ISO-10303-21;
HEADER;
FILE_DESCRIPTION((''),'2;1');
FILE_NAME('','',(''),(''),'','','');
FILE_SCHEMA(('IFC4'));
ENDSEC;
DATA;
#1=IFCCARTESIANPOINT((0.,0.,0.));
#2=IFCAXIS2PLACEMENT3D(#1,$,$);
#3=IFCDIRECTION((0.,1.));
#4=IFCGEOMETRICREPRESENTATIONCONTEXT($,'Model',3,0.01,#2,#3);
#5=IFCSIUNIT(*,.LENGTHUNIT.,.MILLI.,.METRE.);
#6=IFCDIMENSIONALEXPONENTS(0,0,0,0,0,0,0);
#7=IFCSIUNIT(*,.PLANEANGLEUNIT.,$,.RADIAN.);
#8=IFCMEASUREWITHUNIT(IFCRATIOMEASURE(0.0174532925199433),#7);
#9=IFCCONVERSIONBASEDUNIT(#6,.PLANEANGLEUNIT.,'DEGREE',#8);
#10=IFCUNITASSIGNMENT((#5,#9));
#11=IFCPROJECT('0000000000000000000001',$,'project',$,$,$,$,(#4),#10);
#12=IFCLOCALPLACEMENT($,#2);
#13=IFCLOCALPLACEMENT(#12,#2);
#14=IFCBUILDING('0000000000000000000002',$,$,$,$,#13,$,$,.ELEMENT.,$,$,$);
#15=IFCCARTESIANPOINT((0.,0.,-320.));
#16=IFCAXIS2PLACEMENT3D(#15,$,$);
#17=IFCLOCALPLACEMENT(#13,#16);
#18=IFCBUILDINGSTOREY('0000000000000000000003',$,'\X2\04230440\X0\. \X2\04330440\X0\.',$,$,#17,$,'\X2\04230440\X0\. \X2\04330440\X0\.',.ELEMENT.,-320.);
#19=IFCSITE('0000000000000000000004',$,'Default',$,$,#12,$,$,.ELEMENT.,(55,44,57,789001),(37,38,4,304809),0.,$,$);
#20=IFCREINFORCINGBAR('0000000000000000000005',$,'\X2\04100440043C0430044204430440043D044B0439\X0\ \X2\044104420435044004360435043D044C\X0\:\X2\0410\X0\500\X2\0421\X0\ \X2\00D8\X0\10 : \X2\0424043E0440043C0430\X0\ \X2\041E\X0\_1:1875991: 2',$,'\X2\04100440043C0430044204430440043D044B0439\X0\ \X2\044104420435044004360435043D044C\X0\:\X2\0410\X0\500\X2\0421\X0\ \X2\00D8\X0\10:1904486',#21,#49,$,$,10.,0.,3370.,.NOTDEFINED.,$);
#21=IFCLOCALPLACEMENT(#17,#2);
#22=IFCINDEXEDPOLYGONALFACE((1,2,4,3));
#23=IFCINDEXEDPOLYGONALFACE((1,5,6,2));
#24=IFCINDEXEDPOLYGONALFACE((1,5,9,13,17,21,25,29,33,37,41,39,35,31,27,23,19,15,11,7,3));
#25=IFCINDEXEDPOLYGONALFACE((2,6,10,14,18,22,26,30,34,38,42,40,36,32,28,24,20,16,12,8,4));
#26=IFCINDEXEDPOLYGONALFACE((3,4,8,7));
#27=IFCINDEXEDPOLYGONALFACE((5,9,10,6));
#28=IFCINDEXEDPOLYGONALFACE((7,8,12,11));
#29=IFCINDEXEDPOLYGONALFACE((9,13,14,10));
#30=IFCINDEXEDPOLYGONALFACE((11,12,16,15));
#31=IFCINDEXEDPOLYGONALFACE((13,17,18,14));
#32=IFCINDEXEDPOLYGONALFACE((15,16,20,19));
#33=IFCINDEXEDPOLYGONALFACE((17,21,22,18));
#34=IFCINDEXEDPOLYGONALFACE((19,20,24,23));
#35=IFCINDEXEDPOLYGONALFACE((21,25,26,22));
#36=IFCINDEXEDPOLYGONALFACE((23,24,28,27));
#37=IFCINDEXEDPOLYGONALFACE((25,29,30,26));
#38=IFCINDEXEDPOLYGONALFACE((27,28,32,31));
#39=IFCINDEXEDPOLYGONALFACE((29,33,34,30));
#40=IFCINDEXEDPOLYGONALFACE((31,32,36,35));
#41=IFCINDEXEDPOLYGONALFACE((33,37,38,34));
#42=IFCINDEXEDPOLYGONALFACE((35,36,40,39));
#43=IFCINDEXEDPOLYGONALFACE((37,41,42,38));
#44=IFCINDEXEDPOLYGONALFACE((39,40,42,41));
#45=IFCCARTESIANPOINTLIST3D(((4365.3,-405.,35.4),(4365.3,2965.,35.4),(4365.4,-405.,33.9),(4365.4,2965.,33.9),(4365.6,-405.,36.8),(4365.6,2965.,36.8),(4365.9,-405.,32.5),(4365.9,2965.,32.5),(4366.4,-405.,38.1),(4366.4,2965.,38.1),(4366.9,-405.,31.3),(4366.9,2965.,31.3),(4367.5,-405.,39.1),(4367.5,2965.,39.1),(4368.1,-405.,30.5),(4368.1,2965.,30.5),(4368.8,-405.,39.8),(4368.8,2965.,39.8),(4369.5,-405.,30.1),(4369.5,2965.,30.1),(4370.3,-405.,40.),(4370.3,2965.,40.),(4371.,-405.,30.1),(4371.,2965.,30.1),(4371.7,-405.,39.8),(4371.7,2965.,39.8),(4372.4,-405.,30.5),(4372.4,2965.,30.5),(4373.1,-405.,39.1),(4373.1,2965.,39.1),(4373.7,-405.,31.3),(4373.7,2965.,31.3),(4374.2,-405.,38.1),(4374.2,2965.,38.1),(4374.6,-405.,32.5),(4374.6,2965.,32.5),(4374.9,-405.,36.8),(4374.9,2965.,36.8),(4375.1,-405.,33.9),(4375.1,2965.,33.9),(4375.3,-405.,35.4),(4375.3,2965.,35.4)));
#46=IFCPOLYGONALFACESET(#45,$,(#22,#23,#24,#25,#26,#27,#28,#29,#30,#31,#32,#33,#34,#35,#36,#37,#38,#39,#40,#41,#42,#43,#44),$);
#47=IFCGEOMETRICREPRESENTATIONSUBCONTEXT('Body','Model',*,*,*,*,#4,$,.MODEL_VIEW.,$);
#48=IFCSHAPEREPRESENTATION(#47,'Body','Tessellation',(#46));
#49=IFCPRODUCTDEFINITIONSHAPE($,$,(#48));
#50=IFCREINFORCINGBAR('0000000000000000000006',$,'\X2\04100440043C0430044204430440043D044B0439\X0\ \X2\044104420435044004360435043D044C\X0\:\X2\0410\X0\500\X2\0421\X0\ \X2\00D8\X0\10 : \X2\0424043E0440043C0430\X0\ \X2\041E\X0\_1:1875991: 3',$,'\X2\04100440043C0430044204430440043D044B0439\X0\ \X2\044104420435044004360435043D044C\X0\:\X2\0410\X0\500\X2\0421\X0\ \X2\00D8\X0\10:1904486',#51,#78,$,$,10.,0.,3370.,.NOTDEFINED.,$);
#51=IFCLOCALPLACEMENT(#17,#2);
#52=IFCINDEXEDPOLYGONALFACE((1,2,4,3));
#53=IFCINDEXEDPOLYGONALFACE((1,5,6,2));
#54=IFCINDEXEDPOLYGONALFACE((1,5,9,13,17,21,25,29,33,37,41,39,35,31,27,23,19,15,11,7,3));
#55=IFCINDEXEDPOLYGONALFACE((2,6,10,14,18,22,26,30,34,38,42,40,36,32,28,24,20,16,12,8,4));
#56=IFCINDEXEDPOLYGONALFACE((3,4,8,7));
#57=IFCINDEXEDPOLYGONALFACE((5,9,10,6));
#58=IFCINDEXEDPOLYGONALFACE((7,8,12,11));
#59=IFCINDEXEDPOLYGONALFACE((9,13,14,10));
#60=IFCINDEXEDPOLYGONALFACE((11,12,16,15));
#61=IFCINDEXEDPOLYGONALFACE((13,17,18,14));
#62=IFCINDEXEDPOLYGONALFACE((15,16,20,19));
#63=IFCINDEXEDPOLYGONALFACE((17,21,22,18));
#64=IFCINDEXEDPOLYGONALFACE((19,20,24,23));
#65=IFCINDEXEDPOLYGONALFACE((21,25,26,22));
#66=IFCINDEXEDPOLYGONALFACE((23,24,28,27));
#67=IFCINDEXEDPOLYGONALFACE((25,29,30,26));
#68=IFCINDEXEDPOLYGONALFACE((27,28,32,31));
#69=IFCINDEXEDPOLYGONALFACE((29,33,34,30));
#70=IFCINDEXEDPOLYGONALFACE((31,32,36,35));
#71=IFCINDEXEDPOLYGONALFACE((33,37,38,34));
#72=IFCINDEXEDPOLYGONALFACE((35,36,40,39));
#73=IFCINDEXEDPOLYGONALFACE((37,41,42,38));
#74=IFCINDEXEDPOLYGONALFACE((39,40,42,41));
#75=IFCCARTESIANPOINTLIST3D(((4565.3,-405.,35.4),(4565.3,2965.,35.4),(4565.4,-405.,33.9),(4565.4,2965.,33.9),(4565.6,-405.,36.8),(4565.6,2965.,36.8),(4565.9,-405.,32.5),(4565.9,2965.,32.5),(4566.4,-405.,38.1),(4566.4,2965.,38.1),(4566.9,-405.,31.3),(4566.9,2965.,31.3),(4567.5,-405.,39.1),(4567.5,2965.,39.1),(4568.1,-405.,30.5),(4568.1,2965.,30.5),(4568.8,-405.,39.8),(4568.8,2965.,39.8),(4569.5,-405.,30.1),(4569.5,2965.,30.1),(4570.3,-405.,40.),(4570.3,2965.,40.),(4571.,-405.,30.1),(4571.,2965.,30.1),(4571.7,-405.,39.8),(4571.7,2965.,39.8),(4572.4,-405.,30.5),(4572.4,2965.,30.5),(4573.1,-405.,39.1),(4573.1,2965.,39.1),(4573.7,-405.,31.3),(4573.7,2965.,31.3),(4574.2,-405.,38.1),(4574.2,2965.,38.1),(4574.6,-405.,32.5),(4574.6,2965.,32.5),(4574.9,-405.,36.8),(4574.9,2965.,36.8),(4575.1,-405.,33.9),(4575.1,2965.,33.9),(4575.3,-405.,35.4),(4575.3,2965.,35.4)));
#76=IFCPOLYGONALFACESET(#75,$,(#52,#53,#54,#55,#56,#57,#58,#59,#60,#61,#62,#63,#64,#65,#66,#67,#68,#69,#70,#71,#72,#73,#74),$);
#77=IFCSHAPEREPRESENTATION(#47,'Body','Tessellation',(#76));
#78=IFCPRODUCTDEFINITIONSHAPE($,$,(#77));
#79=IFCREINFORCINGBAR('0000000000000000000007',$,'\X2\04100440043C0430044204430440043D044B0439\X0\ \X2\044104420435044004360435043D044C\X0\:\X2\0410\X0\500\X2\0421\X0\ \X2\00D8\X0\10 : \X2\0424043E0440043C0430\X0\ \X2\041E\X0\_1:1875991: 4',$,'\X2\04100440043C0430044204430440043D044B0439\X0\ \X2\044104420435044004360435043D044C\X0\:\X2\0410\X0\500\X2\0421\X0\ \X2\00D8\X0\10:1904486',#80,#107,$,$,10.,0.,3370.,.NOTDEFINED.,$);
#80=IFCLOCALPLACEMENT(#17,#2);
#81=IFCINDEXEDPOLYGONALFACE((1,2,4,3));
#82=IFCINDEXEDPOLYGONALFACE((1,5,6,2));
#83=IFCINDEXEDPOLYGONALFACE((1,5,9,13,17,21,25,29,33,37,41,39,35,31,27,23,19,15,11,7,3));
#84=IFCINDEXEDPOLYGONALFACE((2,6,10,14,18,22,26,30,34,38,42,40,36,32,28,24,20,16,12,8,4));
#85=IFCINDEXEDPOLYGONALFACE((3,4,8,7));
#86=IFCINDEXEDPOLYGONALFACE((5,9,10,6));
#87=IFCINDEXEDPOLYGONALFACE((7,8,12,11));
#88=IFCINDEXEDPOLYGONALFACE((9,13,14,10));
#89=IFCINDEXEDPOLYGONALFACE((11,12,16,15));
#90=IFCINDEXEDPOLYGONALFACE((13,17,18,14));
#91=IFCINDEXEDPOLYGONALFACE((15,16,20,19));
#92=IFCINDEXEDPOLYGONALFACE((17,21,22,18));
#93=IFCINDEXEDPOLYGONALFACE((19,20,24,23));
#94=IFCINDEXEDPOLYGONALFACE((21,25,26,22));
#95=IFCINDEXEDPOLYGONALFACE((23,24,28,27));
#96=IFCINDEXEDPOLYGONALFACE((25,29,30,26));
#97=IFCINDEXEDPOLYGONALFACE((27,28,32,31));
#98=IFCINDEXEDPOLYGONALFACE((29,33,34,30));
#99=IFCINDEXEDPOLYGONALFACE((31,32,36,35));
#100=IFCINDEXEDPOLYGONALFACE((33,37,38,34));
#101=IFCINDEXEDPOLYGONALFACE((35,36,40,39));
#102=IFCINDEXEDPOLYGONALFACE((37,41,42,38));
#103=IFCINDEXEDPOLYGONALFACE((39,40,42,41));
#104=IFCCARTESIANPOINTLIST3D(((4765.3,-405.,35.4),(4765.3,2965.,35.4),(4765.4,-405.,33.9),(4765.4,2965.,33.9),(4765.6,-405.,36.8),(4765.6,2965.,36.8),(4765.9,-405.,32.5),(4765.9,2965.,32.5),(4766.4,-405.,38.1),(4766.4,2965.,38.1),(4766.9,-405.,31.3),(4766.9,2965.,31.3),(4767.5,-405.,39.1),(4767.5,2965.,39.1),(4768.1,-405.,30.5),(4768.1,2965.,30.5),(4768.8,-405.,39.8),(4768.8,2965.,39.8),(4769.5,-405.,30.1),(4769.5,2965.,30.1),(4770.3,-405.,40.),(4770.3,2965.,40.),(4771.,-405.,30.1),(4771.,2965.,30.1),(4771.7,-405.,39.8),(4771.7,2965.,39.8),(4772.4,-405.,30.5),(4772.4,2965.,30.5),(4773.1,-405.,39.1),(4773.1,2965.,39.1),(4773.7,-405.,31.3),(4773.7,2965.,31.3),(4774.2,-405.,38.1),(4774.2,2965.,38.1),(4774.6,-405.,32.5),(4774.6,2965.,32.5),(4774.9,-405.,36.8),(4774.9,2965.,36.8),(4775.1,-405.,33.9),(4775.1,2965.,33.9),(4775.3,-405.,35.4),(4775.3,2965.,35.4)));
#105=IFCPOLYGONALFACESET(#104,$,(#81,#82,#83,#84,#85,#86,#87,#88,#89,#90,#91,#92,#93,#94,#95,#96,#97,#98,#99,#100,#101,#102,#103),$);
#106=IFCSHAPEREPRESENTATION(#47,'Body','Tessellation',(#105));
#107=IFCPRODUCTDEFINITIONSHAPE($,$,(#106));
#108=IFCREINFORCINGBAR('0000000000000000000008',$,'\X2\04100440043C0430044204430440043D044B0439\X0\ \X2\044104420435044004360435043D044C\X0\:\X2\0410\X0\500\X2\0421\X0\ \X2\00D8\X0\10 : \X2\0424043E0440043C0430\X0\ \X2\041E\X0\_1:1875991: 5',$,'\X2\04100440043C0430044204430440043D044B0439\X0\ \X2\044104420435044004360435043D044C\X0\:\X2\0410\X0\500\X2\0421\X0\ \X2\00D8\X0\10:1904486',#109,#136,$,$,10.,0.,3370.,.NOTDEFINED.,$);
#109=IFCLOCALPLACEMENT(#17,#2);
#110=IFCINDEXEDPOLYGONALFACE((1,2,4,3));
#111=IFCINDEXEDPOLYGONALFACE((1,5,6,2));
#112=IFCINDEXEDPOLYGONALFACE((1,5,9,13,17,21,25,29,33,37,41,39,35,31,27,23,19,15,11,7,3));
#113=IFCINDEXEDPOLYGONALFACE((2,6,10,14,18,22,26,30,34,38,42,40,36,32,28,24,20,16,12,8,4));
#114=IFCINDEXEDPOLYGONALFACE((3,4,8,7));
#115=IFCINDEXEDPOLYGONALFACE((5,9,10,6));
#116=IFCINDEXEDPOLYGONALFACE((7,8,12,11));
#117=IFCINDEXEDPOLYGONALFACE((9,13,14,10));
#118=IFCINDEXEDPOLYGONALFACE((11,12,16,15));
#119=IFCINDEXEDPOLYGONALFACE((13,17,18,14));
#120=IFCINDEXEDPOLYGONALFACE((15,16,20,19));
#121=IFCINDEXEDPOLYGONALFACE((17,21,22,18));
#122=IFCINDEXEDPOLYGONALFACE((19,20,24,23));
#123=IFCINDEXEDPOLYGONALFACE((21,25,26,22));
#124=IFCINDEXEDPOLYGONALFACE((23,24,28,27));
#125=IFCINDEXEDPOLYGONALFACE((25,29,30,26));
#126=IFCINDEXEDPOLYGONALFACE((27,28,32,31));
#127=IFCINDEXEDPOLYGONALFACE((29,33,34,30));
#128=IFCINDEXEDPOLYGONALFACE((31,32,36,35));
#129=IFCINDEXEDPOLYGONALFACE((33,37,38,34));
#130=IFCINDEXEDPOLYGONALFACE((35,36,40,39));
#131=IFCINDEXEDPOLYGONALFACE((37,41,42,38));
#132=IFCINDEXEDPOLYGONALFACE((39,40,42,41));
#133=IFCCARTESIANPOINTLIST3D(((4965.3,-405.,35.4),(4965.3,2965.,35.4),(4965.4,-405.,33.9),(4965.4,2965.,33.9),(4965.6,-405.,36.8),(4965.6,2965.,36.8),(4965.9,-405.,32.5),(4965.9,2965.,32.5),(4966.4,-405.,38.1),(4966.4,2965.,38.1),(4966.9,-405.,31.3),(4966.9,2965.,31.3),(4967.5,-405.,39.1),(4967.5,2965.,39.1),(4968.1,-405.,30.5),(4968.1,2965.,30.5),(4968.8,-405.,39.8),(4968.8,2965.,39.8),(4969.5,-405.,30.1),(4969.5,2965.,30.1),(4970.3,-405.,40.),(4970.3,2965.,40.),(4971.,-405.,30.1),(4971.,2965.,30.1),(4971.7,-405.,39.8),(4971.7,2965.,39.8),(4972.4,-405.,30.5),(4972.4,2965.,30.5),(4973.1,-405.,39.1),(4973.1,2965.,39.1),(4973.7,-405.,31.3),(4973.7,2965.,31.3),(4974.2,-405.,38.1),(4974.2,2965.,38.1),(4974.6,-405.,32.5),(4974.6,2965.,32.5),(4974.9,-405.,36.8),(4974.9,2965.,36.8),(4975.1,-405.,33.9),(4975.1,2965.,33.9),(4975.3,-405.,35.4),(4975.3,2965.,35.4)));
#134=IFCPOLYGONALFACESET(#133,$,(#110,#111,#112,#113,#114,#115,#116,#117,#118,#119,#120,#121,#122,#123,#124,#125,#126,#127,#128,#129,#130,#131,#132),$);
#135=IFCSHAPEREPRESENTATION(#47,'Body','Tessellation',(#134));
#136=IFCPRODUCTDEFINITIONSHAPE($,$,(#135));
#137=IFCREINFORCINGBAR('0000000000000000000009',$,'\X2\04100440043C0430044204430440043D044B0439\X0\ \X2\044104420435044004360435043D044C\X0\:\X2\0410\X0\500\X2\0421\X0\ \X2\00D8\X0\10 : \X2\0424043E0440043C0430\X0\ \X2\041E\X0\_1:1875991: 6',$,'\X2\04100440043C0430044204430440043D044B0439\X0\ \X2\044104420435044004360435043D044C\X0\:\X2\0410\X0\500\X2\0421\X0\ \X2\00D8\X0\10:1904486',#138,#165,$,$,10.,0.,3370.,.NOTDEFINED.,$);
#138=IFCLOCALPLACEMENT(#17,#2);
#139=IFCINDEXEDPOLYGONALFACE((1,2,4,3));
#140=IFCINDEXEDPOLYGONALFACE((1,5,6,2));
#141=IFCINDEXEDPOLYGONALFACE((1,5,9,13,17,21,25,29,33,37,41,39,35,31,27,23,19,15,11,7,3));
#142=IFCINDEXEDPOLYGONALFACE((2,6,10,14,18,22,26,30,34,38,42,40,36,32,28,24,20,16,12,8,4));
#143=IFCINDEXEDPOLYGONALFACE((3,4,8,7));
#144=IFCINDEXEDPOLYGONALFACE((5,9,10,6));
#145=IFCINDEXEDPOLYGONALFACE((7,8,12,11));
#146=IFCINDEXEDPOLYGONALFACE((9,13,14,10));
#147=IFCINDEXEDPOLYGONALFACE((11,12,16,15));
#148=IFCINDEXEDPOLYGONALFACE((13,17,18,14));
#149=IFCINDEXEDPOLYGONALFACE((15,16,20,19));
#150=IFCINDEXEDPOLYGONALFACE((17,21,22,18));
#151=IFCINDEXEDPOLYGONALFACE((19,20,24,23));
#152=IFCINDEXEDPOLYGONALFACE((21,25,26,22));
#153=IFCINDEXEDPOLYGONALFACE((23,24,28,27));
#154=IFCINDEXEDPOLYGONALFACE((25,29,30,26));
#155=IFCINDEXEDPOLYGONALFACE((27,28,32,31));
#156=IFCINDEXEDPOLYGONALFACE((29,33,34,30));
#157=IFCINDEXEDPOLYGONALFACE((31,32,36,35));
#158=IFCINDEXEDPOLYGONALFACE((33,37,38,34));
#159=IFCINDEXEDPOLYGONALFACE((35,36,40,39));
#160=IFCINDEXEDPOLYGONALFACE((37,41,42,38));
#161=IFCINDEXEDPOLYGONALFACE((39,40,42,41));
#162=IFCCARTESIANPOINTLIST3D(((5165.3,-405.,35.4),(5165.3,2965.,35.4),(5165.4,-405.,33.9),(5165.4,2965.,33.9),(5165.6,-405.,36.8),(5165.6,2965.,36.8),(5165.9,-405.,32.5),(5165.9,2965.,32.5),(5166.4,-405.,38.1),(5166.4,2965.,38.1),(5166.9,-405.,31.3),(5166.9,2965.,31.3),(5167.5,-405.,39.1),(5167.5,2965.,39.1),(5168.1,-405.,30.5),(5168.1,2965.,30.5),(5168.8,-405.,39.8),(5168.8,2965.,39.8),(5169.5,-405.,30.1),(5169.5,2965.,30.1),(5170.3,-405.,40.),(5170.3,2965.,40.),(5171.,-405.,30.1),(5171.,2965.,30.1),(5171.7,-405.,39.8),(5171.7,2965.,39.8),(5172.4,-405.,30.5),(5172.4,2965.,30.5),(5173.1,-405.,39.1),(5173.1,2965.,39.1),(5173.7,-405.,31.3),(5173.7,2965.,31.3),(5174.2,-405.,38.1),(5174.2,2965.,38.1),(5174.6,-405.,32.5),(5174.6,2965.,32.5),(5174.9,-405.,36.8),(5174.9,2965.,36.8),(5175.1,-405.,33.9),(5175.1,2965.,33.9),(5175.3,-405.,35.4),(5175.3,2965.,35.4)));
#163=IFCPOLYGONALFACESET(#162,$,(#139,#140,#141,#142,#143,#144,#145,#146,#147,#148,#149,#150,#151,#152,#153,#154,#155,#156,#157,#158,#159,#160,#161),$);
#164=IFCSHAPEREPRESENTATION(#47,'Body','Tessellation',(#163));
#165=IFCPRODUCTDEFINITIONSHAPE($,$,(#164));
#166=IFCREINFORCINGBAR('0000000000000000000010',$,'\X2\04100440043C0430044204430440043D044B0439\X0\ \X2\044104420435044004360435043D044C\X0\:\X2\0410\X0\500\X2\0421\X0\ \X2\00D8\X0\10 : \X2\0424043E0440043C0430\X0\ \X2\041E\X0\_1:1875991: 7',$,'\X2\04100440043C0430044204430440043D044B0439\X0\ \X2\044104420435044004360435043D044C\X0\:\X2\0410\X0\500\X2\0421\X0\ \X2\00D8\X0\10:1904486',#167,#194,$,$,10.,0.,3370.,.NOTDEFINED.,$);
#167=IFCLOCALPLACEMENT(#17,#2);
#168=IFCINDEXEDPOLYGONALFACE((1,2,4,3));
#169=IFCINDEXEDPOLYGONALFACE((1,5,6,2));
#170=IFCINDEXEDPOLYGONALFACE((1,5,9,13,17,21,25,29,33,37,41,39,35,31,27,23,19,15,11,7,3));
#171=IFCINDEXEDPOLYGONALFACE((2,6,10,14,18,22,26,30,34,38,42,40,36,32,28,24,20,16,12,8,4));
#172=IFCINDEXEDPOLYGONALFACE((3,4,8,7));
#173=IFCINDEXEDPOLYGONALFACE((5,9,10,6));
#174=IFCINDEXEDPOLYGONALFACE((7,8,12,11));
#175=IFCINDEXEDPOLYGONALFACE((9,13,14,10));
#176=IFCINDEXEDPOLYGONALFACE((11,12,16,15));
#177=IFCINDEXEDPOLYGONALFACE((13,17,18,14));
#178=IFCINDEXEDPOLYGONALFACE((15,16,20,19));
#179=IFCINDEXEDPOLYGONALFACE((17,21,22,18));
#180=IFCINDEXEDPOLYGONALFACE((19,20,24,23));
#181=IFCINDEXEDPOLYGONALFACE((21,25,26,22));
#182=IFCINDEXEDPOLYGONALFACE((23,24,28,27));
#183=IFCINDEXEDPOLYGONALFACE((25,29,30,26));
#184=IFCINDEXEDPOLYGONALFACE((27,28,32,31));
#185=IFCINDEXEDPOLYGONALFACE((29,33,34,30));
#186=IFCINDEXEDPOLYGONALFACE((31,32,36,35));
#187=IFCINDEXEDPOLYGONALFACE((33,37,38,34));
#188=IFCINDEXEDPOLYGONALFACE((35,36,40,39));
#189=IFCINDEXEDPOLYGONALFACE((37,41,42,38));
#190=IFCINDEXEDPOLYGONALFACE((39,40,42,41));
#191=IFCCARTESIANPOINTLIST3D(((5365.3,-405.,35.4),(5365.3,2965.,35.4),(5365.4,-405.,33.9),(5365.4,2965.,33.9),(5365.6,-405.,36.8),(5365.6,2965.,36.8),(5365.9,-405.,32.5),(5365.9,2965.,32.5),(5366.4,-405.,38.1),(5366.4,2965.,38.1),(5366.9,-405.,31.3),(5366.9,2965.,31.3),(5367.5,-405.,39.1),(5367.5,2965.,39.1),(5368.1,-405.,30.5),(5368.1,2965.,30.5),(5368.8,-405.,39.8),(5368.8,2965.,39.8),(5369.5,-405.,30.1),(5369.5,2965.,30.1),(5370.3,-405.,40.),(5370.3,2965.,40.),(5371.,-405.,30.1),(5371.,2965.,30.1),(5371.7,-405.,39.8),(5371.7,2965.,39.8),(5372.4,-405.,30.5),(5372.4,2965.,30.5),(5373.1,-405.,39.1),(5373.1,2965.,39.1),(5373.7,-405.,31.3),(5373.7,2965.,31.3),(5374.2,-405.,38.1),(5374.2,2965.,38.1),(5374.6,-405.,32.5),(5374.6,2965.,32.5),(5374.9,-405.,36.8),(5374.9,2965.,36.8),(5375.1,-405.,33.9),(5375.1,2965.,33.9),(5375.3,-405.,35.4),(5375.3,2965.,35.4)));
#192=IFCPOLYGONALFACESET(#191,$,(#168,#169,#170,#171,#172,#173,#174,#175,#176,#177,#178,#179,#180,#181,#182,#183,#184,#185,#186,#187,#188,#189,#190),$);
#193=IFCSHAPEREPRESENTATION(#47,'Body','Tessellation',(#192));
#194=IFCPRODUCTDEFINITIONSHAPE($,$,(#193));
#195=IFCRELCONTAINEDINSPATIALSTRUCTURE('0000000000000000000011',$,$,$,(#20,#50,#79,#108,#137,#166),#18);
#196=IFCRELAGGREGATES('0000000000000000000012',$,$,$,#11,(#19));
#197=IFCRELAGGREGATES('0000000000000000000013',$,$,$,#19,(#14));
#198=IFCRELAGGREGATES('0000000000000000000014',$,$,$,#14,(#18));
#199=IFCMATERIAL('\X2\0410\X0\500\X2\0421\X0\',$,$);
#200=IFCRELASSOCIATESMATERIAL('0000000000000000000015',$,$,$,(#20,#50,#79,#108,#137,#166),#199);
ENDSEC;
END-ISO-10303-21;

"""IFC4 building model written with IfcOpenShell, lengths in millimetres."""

from ifc_helpers import new_model, entity, si_unit, converted_unit, direction, frame, origin, place, context, subcontext, project, spatial, material, element, save


model = new_model("IFC4")

# Units and contexts
model_context = context("Model", 3, precision=0.01, world=origin(), true_north=direction((0.0, 1.0)))
body_context = subcontext(model_context, "Body", "Model", "MODEL_VIEW")
ifc_project = project(units=[si_unit("LENGTHUNIT", "METRE", prefix="MILLI"), converted_unit("PLANEANGLEUNIT", "DEGREE", entity("IfcRatioMeasure", 0.0174532925199433), si_unit("PLANEANGLEUNIT", "RADIAN"), dimensions=[0, 0, 0, 0, 0, 0, 0])], contexts=[model_context])

# Site, building, storey
site_placement = place(None, origin())
site = spatial("IfcSite", under=ifc_project, at=site_placement, Name="Default", CompositionType="ELEMENT", RefLatitude=(55, 44, 57, 789001), RefLongitude=(37, 38, 4, 304809), RefElevation=0.0)
building_placement = place(site_placement, origin())
building = spatial("IfcBuilding", under=site, at=building_placement, CompositionType="ELEMENT")
storey_placement = place(building_placement, frame((0.0, 0.0, -320.0)))
storey = spatial("IfcBuildingStorey", under=building, at=storey_placement, Name="Ур. гр.", LongName="Ур. гр.", CompositionType="ELEMENT", Elevation=-320.0)

# Reinforcing bars
ifc_material_1 = material(Name="А500С")
reinforcing_bar_1_placement = place(storey_placement, origin())
element("IfcReinforcingBar", 1, at=reinforcing_bar_1_placement, inside=storey, material=ifc_material_1, Name="Арматурный стержень:А500С Ø10 : Форма О_1:1875991: 2", ObjectType="Арматурный стержень:А500С Ø10:1904486", BarLength=3370.0, CrossSectionArea=0.0, NominalDiameter=10.0, PredefinedType="NOTDEFINED", context=body_context, shape_type="AdvancedSweptSolid", body=[
    entity("IfcSweptDiskSolid", entity("IfcCompositeCurve", [entity("IfcCompositeCurveSegment", "CONTINUOUS", True, entity("IfcPolyline", [entity("IfcCartesianPoint", [4370.3, -405.0, 35.0]), entity("IfcCartesianPoint", [4370.3, 2965.0, 35.0])]))], False), 5.0, None, 0.0, 1.0),
])
reinforcing_bar_2_placement = place(storey_placement, origin())
element("IfcReinforcingBar", 2, at=reinforcing_bar_2_placement, inside=storey, material=ifc_material_1, Name="Арматурный стержень:А500С Ø10 : Форма О_1:1875991: 3", ObjectType="Арматурный стержень:А500С Ø10:1904486", BarLength=3370.0, CrossSectionArea=0.0, NominalDiameter=10.0, PredefinedType="NOTDEFINED", context=body_context, shape_type="AdvancedSweptSolid", body=[
    entity("IfcSweptDiskSolid", entity("IfcCompositeCurve", [entity("IfcCompositeCurveSegment", "CONTINUOUS", True, entity("IfcPolyline", [entity("IfcCartesianPoint", [4570.3, -405.0, 35.0]), entity("IfcCartesianPoint", [4570.3, 2965.0, 35.0])]))], False), 5.0, None, 0.0, 1.0),
])
reinforcing_bar_3_placement = place(storey_placement, origin())
element("IfcReinforcingBar", 3, at=reinforcing_bar_3_placement, inside=storey, material=ifc_material_1, Name="Арматурный стержень:А500С Ø10 : Форма О_1:1875991: 4", ObjectType="Арматурный стержень:А500С Ø10:1904486", BarLength=3370.0, CrossSectionArea=0.0, NominalDiameter=10.0, PredefinedType="NOTDEFINED", context=body_context, shape_type="AdvancedSweptSolid", body=[
    entity("IfcSweptDiskSolid", entity("IfcCompositeCurve", [entity("IfcCompositeCurveSegment", "CONTINUOUS", True, entity("IfcPolyline", [entity("IfcCartesianPoint", [4770.3, -405.0, 35.0]), entity("IfcCartesianPoint", [4770.3, 2965.0, 35.0])]))], False), 5.0, None, 0.0, 1.0),
])
reinforcing_bar_4_placement = place(storey_placement, origin())
element("IfcReinforcingBar", 4, at=reinforcing_bar_4_placement, inside=storey, material=ifc_material_1, Name="Арматурный стержень:А500С Ø10 : Форма О_1:1875991: 5", ObjectType="Арматурный стержень:А500С Ø10:1904486", BarLength=3370.0, CrossSectionArea=0.0, NominalDiameter=10.0, PredefinedType="NOTDEFINED", context=body_context, shape_type="AdvancedSweptSolid", body=[
    entity("IfcSweptDiskSolid", entity("IfcCompositeCurve", [entity("IfcCompositeCurveSegment", "CONTINUOUS", True, entity("IfcPolyline", [entity("IfcCartesianPoint", [4970.3, -405.0, 35.0]), entity("IfcCartesianPoint", [4970.3, 2965.0, 35.0])]))], False), 5.0, None, 0.0, 1.0),
])
reinforcing_bar_5_placement = place(storey_placement, origin())
element("IfcReinforcingBar", 5, at=reinforcing_bar_5_placement, inside=storey, material=ifc_material_1, Name="Арматурный стержень:А500С Ø10 : Форма О_1:1875991: 6", ObjectType="Арматурный стержень:А500С Ø10:1904486", BarLength=3370.0, CrossSectionArea=0.0, NominalDiameter=10.0, PredefinedType="NOTDEFINED", context=body_context, shape_type="AdvancedSweptSolid", body=[
    entity("IfcSweptDiskSolid", entity("IfcCompositeCurve", [entity("IfcCompositeCurveSegment", "CONTINUOUS", True, entity("IfcPolyline", [entity("IfcCartesianPoint", [5170.3, -405.0, 35.0]), entity("IfcCartesianPoint", [5170.3, 2965.0, 35.0])]))], False), 5.0, None, 0.0, 1.0),
])
reinforcing_bar_6_placement = place(storey_placement, origin())
element("IfcReinforcingBar", 6, at=reinforcing_bar_6_placement, inside=storey, material=ifc_material_1, Name="Арматурный стержень:А500С Ø10 : Форма О_1:1875991: 7", ObjectType="Арматурный стержень:А500С Ø10:1904486", BarLength=3370.0, CrossSectionArea=0.0, NominalDiameter=10.0, PredefinedType="NOTDEFINED", context=body_context, shape_type="AdvancedSweptSolid", body=[
    entity("IfcSweptDiskSolid", entity("IfcCompositeCurve", [entity("IfcCompositeCurveSegment", "CONTINUOUS", True, entity("IfcPolyline", [entity("IfcCartesianPoint", [5370.3, -405.0, 35.0]), entity("IfcCartesianPoint", [5370.3, 2965.0, 35.0])]))], False), 5.0, None, 0.0, 1.0),
])

save(model, "model.ifc")
